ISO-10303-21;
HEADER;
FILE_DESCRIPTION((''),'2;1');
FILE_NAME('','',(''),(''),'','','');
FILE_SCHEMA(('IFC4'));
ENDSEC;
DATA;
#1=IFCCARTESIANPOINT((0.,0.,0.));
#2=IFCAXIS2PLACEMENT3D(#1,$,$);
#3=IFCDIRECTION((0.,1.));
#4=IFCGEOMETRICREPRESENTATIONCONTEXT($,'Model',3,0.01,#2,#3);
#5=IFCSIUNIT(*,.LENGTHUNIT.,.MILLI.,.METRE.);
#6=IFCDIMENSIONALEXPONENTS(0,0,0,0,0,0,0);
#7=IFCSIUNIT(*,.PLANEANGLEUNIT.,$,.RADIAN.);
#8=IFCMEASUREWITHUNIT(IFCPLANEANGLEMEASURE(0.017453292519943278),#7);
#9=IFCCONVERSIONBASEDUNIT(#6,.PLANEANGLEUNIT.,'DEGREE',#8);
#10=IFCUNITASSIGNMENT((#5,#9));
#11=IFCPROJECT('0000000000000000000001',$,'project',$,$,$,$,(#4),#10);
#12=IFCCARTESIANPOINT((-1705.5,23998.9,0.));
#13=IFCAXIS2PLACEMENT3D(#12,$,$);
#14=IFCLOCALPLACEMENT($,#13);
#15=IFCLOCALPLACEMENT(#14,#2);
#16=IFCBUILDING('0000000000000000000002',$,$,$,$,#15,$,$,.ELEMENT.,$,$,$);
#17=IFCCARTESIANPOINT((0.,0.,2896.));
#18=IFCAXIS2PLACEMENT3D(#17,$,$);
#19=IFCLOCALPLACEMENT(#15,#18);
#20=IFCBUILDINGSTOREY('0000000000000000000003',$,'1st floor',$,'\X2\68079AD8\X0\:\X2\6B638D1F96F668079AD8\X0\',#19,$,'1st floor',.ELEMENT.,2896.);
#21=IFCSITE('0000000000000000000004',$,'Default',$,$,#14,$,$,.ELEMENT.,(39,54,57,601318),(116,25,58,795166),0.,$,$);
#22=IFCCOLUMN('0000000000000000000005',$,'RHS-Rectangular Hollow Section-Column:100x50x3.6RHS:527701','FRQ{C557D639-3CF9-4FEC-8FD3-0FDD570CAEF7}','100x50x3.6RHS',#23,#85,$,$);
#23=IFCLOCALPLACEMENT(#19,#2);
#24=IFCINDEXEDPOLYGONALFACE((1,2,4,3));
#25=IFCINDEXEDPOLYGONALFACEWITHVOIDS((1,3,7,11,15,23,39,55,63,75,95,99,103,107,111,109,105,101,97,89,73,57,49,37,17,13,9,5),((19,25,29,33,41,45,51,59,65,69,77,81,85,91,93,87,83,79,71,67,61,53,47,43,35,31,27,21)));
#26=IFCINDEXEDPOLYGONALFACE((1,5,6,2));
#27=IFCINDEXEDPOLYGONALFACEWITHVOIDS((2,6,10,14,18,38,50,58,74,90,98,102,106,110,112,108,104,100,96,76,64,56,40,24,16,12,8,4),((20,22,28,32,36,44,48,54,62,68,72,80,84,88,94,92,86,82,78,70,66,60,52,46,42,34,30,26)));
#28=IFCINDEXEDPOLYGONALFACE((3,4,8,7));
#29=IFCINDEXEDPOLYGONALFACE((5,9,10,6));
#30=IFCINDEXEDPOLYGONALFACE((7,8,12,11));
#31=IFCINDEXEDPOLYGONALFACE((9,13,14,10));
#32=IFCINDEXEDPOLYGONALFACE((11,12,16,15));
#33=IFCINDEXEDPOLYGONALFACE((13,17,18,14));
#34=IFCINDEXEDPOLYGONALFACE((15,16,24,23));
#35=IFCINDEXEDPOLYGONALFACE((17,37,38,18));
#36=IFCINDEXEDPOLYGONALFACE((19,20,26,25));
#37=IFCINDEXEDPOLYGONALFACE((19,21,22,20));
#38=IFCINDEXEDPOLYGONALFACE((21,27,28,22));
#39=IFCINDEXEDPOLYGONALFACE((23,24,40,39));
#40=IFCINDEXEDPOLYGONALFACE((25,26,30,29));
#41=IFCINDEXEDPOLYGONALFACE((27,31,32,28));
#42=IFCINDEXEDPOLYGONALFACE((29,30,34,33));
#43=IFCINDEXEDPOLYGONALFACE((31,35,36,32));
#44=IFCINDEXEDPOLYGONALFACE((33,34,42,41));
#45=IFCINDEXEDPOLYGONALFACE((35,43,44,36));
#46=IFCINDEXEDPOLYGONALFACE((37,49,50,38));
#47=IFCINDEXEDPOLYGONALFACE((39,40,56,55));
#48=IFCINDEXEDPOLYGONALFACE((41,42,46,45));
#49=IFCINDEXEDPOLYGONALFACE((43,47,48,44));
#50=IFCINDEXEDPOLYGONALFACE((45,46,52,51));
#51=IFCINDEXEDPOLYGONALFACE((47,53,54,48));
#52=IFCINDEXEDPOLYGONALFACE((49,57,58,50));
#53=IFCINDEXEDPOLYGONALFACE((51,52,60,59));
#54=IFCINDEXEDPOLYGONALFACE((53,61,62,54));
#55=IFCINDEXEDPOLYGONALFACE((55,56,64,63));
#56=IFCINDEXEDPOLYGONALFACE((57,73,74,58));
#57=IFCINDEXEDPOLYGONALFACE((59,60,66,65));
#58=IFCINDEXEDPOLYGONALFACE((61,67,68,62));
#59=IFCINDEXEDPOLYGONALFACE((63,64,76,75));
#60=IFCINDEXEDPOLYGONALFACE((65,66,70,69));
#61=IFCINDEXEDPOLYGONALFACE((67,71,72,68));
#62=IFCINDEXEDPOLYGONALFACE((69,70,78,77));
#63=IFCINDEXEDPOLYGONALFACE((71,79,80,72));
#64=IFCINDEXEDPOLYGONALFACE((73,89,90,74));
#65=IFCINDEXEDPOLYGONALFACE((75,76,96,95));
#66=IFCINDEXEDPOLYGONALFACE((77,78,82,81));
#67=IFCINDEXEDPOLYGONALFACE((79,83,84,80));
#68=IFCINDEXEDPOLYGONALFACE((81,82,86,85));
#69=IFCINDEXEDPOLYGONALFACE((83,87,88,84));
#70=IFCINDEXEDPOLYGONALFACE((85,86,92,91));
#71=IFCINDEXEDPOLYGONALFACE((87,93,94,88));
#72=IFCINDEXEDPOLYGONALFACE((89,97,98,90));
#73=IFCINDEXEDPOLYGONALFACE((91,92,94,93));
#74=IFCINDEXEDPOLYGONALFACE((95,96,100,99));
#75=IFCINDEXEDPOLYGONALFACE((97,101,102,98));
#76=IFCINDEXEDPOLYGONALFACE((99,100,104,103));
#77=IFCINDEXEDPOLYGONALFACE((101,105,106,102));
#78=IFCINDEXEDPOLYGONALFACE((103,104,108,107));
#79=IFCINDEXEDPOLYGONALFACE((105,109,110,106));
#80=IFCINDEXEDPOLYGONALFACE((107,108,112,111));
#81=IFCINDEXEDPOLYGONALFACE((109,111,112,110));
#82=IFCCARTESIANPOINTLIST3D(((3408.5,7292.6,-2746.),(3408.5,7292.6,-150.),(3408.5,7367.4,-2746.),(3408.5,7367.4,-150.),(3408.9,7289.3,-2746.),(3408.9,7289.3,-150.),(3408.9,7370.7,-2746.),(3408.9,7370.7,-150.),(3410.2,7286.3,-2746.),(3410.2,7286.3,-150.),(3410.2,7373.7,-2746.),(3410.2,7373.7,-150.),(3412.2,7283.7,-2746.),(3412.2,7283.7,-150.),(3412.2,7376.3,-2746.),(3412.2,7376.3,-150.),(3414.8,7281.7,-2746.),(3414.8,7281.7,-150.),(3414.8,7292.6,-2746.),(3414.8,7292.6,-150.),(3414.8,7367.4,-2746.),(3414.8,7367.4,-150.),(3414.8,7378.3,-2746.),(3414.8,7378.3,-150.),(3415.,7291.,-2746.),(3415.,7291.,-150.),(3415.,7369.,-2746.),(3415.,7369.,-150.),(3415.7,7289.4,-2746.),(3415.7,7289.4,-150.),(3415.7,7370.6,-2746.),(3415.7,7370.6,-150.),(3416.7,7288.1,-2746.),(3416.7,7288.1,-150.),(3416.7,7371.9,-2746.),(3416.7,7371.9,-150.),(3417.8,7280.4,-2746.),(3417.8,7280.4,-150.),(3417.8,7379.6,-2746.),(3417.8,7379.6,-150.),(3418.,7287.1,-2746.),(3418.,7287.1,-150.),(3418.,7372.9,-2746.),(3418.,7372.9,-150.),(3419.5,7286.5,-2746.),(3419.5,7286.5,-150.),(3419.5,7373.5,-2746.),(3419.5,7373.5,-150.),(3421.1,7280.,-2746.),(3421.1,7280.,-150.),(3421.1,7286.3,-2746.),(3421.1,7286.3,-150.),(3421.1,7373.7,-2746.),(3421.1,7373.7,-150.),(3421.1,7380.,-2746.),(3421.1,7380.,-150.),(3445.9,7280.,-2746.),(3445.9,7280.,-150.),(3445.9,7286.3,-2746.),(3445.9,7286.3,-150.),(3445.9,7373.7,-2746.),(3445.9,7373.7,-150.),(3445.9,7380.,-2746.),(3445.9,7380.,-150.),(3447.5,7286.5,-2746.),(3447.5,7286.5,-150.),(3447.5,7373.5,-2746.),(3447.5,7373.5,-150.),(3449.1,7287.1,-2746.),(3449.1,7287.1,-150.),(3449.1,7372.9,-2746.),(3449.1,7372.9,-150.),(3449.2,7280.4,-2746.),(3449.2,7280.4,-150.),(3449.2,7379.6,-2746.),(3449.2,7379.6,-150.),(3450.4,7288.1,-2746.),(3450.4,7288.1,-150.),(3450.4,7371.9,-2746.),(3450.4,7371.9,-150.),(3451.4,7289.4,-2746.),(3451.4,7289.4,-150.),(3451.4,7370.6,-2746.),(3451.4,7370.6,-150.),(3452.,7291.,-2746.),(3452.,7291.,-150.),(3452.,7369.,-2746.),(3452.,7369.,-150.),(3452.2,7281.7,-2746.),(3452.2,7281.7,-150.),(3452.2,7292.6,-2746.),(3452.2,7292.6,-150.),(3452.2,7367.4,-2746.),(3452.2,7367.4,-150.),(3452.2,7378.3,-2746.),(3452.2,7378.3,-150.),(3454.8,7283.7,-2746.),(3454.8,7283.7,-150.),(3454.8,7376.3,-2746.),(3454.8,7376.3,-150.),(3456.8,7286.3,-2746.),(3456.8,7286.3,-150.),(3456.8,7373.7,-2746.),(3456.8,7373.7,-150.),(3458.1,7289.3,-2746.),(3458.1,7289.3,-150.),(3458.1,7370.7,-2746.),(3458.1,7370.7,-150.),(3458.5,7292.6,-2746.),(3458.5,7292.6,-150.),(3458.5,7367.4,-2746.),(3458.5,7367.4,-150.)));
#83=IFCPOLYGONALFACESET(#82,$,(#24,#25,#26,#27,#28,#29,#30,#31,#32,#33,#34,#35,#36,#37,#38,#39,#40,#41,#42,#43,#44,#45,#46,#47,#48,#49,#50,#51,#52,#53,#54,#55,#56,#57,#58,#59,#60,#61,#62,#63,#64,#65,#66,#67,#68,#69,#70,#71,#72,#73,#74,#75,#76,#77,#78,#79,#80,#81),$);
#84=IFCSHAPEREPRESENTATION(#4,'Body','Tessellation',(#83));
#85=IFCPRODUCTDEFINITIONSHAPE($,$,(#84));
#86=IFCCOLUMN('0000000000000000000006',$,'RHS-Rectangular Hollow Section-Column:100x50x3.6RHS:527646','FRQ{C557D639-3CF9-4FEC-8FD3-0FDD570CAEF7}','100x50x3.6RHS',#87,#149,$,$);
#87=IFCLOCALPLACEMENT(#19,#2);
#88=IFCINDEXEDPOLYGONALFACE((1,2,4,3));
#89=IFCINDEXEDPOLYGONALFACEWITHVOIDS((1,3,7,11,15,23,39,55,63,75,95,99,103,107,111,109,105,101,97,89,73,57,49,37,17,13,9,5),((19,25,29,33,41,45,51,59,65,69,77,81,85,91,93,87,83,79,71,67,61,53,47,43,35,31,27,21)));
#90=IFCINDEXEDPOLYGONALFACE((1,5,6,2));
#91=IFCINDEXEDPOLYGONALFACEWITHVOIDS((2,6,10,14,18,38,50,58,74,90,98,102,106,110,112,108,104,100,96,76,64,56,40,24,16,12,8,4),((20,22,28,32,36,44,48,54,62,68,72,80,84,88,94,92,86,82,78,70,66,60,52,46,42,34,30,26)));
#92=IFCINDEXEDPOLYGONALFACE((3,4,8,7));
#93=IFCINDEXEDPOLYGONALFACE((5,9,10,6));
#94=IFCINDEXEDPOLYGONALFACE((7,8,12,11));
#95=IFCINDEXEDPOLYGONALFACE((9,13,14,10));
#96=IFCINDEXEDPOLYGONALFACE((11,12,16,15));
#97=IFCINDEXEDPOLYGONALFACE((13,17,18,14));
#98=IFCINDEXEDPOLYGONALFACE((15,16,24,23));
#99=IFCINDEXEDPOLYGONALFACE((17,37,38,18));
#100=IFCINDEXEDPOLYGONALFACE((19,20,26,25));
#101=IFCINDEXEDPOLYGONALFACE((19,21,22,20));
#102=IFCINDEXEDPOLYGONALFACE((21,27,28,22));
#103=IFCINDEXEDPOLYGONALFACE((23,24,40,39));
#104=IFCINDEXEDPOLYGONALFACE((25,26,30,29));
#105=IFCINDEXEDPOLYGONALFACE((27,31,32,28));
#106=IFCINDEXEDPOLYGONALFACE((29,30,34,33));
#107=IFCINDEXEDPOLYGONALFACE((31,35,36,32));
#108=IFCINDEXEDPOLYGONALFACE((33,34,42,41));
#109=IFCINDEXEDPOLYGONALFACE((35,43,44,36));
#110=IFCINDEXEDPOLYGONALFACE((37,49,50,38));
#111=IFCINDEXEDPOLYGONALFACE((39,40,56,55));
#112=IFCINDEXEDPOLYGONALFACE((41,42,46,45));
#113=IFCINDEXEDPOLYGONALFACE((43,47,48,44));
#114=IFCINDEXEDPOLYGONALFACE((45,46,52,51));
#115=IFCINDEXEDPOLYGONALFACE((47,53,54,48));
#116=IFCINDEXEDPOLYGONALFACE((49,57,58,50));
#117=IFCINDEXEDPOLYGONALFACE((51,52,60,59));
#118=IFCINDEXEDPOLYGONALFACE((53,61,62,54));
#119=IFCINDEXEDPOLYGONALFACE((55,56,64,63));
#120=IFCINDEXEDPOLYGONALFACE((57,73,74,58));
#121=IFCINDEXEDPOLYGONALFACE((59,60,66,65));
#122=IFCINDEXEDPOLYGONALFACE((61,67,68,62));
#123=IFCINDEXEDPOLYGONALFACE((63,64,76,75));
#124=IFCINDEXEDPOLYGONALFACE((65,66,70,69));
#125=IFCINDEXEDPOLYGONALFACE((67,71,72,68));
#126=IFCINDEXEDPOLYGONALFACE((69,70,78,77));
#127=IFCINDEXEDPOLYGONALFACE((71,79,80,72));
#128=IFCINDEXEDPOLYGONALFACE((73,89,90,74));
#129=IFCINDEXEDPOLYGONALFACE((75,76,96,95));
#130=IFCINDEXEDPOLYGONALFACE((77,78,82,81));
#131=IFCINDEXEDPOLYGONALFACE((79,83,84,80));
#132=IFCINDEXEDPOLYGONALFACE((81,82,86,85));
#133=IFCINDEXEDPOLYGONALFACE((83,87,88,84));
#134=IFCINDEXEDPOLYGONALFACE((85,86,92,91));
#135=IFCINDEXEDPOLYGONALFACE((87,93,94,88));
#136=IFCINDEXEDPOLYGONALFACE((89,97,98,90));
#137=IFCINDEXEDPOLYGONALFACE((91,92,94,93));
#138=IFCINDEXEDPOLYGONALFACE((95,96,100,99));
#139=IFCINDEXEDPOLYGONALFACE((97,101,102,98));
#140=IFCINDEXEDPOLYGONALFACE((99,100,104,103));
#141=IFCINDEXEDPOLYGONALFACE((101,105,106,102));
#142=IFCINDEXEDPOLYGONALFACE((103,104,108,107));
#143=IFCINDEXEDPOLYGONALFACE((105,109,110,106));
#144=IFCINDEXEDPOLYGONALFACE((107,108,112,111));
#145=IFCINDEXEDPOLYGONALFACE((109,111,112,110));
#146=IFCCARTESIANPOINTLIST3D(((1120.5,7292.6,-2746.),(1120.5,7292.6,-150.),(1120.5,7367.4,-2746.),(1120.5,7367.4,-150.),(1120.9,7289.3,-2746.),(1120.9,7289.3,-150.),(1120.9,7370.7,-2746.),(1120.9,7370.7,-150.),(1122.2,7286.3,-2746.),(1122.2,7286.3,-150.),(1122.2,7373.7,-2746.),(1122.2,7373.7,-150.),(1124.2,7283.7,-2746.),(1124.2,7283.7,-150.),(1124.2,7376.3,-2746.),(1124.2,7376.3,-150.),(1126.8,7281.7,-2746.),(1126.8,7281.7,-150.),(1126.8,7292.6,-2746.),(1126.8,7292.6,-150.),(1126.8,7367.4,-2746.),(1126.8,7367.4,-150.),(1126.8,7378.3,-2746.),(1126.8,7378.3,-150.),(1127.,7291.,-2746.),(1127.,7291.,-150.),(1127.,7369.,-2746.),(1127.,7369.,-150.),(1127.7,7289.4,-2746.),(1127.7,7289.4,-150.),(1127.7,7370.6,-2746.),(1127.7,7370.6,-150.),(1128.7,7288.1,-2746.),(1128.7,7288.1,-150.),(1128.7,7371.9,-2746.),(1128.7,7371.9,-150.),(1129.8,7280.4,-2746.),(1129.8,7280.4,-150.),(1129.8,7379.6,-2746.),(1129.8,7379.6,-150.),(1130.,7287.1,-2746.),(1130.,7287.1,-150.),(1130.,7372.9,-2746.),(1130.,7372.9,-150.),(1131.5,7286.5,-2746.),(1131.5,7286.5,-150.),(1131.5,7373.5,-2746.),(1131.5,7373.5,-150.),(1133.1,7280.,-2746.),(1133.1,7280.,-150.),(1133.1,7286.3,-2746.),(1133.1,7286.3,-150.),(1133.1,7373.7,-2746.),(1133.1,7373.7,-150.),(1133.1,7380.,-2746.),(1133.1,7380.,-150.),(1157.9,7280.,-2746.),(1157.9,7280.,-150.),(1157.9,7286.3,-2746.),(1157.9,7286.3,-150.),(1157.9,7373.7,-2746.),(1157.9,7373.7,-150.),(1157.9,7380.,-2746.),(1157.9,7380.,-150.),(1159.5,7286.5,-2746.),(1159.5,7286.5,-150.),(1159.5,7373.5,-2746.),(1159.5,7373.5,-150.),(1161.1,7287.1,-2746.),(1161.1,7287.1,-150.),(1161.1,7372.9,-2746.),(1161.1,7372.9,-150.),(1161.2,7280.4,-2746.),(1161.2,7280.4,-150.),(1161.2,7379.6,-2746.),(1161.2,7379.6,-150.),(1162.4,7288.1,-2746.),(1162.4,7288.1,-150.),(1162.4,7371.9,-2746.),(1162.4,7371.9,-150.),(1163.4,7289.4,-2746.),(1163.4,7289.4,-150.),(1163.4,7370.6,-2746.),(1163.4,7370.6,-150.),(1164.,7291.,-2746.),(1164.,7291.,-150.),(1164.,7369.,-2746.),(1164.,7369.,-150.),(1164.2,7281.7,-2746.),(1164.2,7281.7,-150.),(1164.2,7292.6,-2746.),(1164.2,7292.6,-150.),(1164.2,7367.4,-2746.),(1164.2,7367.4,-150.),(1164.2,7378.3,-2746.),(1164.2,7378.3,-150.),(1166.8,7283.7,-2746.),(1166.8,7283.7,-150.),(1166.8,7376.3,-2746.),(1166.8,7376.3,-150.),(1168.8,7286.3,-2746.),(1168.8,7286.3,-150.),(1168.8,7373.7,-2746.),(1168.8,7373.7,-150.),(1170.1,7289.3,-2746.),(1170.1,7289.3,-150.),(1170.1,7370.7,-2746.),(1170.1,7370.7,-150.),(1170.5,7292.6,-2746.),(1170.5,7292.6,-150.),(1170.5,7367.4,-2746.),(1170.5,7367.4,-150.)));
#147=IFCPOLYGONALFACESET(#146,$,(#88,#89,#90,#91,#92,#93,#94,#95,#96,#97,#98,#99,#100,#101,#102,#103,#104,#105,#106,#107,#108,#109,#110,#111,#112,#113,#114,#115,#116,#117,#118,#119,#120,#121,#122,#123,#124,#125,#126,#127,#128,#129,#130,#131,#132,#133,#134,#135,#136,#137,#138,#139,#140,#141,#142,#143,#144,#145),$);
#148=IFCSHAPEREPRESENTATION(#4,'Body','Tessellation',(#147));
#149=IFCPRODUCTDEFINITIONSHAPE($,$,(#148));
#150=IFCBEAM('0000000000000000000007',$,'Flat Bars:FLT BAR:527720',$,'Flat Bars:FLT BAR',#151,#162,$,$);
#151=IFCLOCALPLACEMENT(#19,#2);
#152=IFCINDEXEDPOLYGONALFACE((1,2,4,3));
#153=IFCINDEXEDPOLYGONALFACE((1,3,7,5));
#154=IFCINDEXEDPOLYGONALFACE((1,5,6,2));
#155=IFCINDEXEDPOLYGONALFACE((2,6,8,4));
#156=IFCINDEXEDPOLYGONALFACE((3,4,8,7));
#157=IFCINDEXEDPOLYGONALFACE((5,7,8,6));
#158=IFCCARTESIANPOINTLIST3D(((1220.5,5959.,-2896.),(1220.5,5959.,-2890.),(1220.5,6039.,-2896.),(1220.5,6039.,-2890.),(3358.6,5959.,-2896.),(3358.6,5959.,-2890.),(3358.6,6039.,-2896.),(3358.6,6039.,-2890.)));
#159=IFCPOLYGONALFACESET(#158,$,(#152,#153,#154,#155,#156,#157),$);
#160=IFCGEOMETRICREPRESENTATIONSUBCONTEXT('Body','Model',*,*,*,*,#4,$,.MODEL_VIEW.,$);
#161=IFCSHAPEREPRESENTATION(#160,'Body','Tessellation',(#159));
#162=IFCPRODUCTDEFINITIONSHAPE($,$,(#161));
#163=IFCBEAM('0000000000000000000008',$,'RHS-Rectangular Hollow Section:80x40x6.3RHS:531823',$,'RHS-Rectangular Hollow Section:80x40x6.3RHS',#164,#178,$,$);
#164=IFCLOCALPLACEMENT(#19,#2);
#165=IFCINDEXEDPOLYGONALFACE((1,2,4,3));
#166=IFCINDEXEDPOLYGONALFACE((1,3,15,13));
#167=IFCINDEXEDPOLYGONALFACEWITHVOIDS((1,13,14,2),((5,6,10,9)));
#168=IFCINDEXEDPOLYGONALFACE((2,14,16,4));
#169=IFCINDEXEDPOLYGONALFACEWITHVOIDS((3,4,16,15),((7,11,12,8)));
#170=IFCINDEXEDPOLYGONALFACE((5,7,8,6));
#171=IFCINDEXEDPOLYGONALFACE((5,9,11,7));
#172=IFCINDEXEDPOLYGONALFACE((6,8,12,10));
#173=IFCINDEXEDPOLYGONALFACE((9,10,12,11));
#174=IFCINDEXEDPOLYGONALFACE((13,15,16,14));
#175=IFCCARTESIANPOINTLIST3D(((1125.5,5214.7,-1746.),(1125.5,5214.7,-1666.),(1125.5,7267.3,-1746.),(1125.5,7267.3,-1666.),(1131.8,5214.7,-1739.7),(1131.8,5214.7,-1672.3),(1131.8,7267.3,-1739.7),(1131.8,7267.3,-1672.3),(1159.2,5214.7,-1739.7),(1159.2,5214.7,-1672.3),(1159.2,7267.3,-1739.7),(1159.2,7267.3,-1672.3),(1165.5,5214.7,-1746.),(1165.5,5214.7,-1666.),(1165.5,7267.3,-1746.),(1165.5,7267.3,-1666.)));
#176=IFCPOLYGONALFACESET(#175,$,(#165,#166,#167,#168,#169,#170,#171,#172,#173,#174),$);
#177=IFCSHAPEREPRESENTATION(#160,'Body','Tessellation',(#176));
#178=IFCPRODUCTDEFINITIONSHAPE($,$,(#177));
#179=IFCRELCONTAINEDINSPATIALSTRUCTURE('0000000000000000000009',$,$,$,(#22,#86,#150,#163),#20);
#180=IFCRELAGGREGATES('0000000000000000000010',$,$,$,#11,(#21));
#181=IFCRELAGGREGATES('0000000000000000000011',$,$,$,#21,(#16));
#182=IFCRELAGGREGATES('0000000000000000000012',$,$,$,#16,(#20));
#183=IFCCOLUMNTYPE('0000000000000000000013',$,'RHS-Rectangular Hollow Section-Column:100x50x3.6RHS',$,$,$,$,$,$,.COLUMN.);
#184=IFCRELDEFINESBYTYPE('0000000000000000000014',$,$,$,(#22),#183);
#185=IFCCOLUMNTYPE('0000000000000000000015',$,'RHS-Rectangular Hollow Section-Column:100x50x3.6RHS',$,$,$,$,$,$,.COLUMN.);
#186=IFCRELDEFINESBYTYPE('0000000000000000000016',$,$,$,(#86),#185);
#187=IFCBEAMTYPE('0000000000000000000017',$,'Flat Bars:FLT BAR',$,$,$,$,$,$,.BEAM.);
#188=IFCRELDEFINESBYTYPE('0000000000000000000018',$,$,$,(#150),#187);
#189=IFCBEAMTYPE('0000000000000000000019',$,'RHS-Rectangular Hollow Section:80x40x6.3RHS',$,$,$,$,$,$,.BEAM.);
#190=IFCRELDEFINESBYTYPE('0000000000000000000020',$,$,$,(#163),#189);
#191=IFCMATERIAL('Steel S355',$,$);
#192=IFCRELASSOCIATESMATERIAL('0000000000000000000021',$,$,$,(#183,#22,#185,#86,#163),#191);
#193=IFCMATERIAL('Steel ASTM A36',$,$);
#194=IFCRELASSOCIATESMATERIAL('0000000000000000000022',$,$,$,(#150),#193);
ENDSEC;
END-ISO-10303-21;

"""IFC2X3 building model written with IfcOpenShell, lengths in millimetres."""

from ifc_helpers import new_model, entity, si_unit, converted_unit, point, direction, frame, frame_2d, origin, origin_2d, origin_2d_with_axis, place, context, subcontext, project, spatial, circle_curve, line_curve, trimmed, segment, composite_curve, rectangle, hollow_rectangle, outline, extrude, boolean, clip, halfspace, material, type_object, element, save


model = new_model("IFC2X3")

# Units and contexts
model_context = context("Model", 3, precision=0.01, world=origin(), true_north=direction((0.0, 1.0)))
body_context = subcontext(model_context, "Body", "Model", "MODEL_VIEW")
ifc_project = project(units=[si_unit("LENGTHUNIT", "METRE", prefix="MILLI"), converted_unit("PLANEANGLEUNIT", "DEGREE", entity("IfcPlaneAngleMeasure", 0.017453292519943278), si_unit("PLANEANGLEUNIT", "RADIAN"), dimensions=[0, 0, 0, 0, 0, 0, 0])], contexts=[model_context])

# Site, building, storey
site_placement = place(None, frame((-1705.5, 23998.9, 0.0)))
site = spatial("IfcSite", under=ifc_project, at=site_placement, Name="Default", CompositionType="ELEMENT", RefLatitude=(39, 54, 57, 601318), RefLongitude=(116, 25, 58, 795166), RefElevation=0.0)
building_placement = place(site_placement, origin())
building = spatial("IfcBuilding", under=site, at=building_placement, CompositionType="ELEMENT")
storey_placement = place(building_placement, frame((0.0, 0.0, 2896.0)))
storey = spatial("IfcBuildingStorey", under=building, at=storey_placement, Name="1st floor", ObjectType="标高:正负零标高", LongName="1st floor", CompositionType="ELEMENT", Elevation=2896.0)

# Column
ifc_material_1 = material(Name="Steel S355")
column_type_1 = type_object("IfcColumnType", Name="RHS-Rectangular Hollow Section-Column:100x50x3.6RHS", PredefinedType="COLUMN", material=ifc_material_1)
column_1_placement = place(storey_placement, frame((3433.5, 7330.0, -150.0), z_axis=(0.0, 0.0, 1.0), x_axis=(-1.0, 0.0, 0.0)))
element("IfcColumn", 1, at=column_1_placement, inside=storey, type_object=column_type_1, material=ifc_material_1, Name="RHS-Rectangular Hollow Section-Column:100x50x3.6RHS:527701", Description="FRQ{C557D639-3CF9-4FEC-8FD3-0FDD570CAEF7}", ObjectType="100x50x3.6RHS", context=model_context, shape_type="Clipping", body=[
    clip(extrude(hollow_rectangle(XDim=50.0, YDim=100.0, WallThickness=6.3, InnerFilletRadius=6.3, OuterFilletRadius=12.6, at=origin_2d()), origin(), (0.0, 0.0, -1.0), 2651.9), halfspace(frame((3433.5, 7330.0, -2596.0), z_axis=(0.0, 0.0, 1.0), x_axis=(-1.0, 0.0, 0.0)), True)),
])

# Column, opening
column_type_2 = type_object("IfcColumnType", Name="RHS-Rectangular Hollow Section-Column:100x50x3.6RHS", PredefinedType="COLUMN", material=ifc_material_1)
column_2_placement = place(storey_placement, frame((1145.5, 7330.0, -19.1)))
column_2 = element("IfcColumn", 2, at=column_2_placement, inside=storey, type_object=column_type_2, material=ifc_material_1, Name="RHS-Rectangular Hollow Section-Column:100x50x3.6RHS:527646", Description="FRQ{C557D639-3CF9-4FEC-8FD3-0FDD570CAEF7}", ObjectType="100x50x3.6RHS", context=model_context, shape_type="Clipping", body=[
    clip(clip(extrude(hollow_rectangle(XDim=50.0, YDim=100.0, WallThickness=6.3, InnerFilletRadius=6.3, OuterFilletRadius=12.6, at=origin_2d()), origin(), (0.0, 0.0, -1.0), 2782.8), halfspace(frame((-1145.5, -7330.0, -2726.9), z_axis=(0.0, 0.0, 1.0), x_axis=(1.0, 0.0, 0.0)), True)), halfspace(frame((-1145.5, -7330.0, -55.9), z_axis=(0.0, 0.0, -1.0), x_axis=(-1.0, 0.0, 0.0)), True)),
])
opening_1_placement = place(column_2_placement, frame((0.0, -150.1, -130.9), z_axis=(0.0, 1.0, 0.0), x_axis=(-1.0, 0.0, 0.0)))
element("IfcOpeningElement", 3, at=opening_1_placement, cuts=column_2, ObjectType="Opening", context=model_context, shape_type="SweptSolid", body=[
    extrude(outline(composite_curve([segment(trimmed(circle_curve(frame_2d((43.0, 32.0), x_axis=(1.0, 0.0)), 32.0), [point((43.0, 0.0))], [point((75.0, 32.0))], True, "CARTESIAN"), True, "CONTINUOUS"), segment(trimmed(line_curve((75.0, 32.0), (0.0, 1.0), 86.0), [point((75.0, 32.0))], [point((75.0, 118.0))], True, "CARTESIAN"), True, "CONTINUOUS"), segment(trimmed(circle_curve(frame_2d((43.0, 118.0), x_axis=(1.0, 0.0)), 32.0), [point((75.0, 118.0))], [point((43.0, 150.0))], True, "CARTESIAN"), True, "CONTINUOUS"), segment(trimmed(line_curve((43.0, 150.0), (-1.0, 0.0), 86.0), [point((43.0, 150.0))], [point((-43.0, 150.0))], True, "CARTESIAN"), True, "CONTINUOUS"), segment(trimmed(circle_curve(frame_2d((-43.0, 118.0), x_axis=(1.0, 0.0)), 32.0), [point((-43.0, 150.0))], [point((-75.0, 118.0))], True, "CARTESIAN"), True, "CONTINUOUS"), segment(trimmed(line_curve((-75.0, 118.0), (0.0, -1.0), 86.0), [point((-75.0, 118.0))], [point((-75.0, 32.0))], True, "CARTESIAN"), True, "CONTINUOUS"), segment(trimmed(circle_curve(frame_2d((-43.0, 32.0), x_axis=(1.0, 0.0)), 32.0), [point((-75.0, 32.0))], [point((-43.0, 0.0))], True, "CARTESIAN"), True, "CONTINUOUS"), segment(trimmed(line_curve((-43.0, 0.0), (1.0, 0.0), 86.0), [point((-43.0, 0.0))], [point((43.0, 0.0))], True, "CARTESIAN"), True, "CONTINUOUS")], self_intersect="UNKNOWN")), origin(), (0.0, 0.0, 1.0), 300.2),
])

# Beams
ifc_material_2 = material(Name="Steel ASTM A36")
beam_type_1 = type_object("IfcBeamType", Name="Flat Bars:FLT BAR", PredefinedType="BEAM")
beam_1_placement = place(storey_placement, frame((1220.5, 5999.0, -2890.0)))
element("IfcBeam", 4, at=beam_1_placement, inside=storey, type_object=beam_type_1, material=ifc_material_2, Name="Flat Bars:FLT BAR:527720", ObjectType="Flat Bars:FLT BAR", context=body_context, shape_type="SweptSolid", body=[
    extrude(rectangle(XDim=6.0, YDim=80.0, at=origin_2d_with_axis()), frame((0.0, 0.0, -3.0), z_axis=(1.0, 0.0, 0.0), x_axis=(0.0, 0.0, -1.0)), (0.0, 0.0, 1.0), 2138.1),
])
beam_type_2 = type_object("IfcBeamType", Name="RHS-Rectangular Hollow Section:80x40x6.3RHS", PredefinedType="BEAM")
beam_2_placement = place(storey_placement, frame((1145.5, 7330.0, -1666.0), z_axis=(0.0, 0.0, 1.0), x_axis=(0.0, -1.0, 0.0)))
element("IfcBeam", 5, at=beam_2_placement, inside=storey, type_object=beam_type_2, material=ifc_material_1, Name="RHS-Rectangular Hollow Section:80x40x6.3RHS:531823", ObjectType="RHS-Rectangular Hollow Section:80x40x6.3RHS", context=body_context, shape_type="SweptSolid", body=[
    boolean("DIFFERENCE", extrude(rectangle(XDim=80.0, YDim=40.0, at=frame_2d((0.0, 0.0), x_axis=(1.0, 0.0))), frame((62.7, 0.0, -40.0), z_axis=(1.0, 0.0, 0.0), x_axis=(0.0, 0.0, -1.0)), (0.0, 0.0, 1.0), 2052.6), extrude(rectangle(XDim=67.4, YDim=27.4, at=frame_2d((0.0, 0.0), x_axis=(0.0, 1.0))), frame((2115.3, 0.0, -40.0), z_axis=(-1.0, 0.0, 0.0), x_axis=(0.0, 1.0, 0.0)), (0.0, 0.0, 1.0), 2052.6)),
])

save(model, "model.ifc")
